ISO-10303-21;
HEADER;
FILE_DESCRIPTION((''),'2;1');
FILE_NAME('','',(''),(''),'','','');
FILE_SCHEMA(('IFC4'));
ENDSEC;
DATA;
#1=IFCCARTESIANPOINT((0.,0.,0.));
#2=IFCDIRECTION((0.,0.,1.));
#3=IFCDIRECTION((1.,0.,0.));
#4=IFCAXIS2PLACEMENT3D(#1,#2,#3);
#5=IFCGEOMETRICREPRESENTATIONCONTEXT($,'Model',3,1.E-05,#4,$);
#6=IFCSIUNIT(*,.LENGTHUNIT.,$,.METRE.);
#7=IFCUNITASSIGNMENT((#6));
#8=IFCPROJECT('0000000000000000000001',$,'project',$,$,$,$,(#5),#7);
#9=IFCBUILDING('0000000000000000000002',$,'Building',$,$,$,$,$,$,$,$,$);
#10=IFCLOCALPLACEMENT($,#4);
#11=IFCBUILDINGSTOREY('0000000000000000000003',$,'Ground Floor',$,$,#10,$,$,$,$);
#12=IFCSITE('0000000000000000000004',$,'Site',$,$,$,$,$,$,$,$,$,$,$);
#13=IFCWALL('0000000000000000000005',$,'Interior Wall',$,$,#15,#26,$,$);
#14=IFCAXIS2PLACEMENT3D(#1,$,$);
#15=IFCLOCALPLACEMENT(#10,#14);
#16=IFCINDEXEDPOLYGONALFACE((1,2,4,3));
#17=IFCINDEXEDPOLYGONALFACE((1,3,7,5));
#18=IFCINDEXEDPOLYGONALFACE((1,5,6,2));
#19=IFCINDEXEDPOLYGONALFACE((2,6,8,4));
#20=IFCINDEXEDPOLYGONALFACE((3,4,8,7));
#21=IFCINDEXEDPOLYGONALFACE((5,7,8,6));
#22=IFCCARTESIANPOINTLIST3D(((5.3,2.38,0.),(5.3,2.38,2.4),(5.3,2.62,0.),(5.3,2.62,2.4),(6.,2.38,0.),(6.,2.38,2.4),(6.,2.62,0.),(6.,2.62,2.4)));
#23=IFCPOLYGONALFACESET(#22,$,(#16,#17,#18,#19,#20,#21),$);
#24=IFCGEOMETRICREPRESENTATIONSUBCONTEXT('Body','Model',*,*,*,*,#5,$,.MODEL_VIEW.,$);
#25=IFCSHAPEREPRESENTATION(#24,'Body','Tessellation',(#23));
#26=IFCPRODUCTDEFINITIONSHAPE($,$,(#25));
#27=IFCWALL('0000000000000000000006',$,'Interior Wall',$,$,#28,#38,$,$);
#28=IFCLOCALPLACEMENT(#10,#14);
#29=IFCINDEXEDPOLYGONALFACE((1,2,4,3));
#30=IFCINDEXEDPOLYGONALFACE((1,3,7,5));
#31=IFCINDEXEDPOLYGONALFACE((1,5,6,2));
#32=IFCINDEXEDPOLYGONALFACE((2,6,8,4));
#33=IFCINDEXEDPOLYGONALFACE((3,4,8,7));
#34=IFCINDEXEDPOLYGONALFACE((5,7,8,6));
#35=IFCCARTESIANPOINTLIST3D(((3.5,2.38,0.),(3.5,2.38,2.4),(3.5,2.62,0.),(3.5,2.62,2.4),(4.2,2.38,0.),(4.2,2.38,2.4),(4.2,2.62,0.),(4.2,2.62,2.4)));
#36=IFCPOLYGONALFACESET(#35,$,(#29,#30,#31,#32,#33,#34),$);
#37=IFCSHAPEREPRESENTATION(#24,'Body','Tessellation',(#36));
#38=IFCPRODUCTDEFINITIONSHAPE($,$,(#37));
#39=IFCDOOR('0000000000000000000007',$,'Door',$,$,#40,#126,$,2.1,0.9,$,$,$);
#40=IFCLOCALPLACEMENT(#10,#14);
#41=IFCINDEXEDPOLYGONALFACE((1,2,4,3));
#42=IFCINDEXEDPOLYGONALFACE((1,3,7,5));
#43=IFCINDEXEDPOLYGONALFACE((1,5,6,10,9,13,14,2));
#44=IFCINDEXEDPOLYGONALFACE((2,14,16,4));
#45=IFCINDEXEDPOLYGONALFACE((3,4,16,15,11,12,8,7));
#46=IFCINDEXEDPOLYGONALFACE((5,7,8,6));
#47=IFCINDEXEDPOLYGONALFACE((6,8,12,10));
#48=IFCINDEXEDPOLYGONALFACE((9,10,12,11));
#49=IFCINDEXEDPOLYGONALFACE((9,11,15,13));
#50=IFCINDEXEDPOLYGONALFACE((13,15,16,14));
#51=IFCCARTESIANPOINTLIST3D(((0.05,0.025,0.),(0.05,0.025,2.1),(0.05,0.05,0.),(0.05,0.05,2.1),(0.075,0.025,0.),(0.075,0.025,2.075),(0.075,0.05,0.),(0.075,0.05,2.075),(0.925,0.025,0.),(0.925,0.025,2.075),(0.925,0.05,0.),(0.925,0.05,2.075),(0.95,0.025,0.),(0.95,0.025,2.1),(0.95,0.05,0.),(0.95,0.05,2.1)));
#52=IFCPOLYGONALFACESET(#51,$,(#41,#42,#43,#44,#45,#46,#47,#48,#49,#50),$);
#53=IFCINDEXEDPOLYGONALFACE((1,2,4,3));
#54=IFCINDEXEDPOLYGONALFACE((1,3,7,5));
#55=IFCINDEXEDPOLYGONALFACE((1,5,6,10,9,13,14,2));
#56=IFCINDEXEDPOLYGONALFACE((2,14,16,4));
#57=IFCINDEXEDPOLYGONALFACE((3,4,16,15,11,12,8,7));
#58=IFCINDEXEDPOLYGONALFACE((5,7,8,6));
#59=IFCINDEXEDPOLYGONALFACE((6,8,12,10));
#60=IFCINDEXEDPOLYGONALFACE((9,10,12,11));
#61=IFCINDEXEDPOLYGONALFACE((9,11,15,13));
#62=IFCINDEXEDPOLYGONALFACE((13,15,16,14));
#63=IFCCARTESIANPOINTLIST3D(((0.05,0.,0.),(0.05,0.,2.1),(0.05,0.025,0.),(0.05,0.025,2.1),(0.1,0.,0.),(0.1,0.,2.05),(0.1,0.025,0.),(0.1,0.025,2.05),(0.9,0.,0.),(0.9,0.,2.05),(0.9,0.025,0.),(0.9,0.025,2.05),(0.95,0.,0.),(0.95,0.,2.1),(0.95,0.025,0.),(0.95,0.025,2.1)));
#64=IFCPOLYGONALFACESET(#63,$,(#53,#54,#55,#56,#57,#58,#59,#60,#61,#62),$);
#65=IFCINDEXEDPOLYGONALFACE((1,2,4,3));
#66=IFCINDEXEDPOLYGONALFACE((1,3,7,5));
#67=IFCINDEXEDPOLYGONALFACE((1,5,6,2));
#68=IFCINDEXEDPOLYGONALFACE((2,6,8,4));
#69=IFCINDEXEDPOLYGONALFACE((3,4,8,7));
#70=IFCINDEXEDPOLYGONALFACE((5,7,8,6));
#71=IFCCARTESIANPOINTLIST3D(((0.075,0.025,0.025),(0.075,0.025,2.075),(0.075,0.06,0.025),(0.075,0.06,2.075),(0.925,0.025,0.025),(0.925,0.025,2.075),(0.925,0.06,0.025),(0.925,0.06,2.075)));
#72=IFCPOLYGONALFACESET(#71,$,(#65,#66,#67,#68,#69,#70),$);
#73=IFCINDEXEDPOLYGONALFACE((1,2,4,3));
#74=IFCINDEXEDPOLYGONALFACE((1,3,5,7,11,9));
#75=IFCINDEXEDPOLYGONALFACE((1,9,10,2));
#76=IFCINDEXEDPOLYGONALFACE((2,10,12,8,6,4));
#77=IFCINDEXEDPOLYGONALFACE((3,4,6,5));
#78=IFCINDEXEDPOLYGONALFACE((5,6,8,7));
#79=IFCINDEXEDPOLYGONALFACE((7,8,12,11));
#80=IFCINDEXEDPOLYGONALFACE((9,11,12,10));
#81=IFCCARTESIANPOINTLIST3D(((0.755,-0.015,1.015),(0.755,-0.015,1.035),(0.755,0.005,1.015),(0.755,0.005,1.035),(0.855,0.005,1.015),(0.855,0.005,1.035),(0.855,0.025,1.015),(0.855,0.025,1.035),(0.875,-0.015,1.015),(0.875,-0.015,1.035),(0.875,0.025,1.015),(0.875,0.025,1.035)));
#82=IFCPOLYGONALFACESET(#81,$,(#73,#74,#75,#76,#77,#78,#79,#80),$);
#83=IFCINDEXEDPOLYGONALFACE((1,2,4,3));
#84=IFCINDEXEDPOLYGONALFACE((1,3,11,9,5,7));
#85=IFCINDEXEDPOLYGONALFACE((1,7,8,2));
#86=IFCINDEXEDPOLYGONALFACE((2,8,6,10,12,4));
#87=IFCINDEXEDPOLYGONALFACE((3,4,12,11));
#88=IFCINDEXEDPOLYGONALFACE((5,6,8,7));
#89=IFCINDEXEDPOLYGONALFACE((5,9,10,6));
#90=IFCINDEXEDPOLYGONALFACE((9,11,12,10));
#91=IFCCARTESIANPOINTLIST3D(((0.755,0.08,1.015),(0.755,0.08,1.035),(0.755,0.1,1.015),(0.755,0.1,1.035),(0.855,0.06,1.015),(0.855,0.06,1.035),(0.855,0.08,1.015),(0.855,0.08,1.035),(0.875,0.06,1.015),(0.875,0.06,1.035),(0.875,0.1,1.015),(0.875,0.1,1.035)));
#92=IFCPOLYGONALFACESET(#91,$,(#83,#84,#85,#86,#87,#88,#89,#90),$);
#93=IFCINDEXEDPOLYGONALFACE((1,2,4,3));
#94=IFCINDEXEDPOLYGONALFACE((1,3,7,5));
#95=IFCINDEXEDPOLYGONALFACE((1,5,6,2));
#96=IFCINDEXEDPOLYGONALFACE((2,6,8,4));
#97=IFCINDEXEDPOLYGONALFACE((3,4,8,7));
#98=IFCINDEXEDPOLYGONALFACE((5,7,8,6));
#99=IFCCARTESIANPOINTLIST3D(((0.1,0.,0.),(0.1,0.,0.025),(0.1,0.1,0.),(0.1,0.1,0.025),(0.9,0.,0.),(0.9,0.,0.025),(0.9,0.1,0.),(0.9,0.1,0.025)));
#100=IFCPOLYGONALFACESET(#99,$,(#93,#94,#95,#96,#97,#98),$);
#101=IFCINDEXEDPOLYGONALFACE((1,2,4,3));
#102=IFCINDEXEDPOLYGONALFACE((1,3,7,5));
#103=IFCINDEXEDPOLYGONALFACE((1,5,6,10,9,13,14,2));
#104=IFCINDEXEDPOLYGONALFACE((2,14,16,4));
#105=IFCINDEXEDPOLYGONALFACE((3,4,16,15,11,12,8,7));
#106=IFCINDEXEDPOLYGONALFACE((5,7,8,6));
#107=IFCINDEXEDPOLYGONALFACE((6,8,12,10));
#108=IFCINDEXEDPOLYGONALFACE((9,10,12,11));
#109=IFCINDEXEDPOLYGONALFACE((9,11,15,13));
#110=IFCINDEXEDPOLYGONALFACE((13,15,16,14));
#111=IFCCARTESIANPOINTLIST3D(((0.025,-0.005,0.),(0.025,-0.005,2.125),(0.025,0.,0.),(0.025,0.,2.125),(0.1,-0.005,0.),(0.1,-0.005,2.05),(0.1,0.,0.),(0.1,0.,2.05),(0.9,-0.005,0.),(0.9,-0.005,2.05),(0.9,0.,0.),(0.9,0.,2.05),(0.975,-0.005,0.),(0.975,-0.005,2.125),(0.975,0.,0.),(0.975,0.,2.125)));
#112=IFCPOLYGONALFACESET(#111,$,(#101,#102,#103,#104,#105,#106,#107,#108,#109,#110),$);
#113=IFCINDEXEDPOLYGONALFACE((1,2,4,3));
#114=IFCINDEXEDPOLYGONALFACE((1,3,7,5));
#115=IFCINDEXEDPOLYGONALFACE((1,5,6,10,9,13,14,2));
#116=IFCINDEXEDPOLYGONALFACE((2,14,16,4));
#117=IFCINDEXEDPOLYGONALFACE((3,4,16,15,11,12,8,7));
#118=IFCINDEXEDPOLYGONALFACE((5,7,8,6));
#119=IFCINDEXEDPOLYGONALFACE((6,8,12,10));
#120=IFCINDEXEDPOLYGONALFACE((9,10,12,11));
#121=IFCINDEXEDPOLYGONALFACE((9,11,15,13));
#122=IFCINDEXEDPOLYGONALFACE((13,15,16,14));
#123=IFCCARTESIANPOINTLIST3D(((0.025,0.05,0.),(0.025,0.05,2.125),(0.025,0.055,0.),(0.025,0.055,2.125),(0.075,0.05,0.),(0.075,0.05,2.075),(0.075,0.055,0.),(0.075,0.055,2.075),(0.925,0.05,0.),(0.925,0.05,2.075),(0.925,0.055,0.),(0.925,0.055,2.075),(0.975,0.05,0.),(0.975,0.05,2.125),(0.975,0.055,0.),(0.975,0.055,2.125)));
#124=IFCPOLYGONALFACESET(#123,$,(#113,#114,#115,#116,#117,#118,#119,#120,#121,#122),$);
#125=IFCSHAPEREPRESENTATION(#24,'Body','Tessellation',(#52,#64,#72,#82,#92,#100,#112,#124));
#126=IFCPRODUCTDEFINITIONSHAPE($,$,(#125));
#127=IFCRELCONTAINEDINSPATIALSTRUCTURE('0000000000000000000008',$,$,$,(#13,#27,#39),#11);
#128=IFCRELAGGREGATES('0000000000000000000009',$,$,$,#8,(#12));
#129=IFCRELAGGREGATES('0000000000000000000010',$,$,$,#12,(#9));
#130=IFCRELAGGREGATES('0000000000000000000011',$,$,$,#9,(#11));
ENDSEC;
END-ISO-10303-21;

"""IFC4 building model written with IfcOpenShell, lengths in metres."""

from ifc_helpers import new_model, si_unit, frame, origin_with_axes, place, context, subcontext, project, spatial, line, indexed_curve, outline, extrude, element, save


model = new_model("IFC4")

# Units and contexts
model_context = context("Model", 3, precision=1e-05, world=origin_with_axes())
body_context = subcontext(model_context, "Body", "Model", "MODEL_VIEW")
ifc_project = project(units=[si_unit("LENGTHUNIT", "METRE")], contexts=[model_context])

# Site, building, storey
site = spatial("IfcSite", under=ifc_project, Name="Site")
building = spatial("IfcBuilding", under=site, Name="Building")
storey_placement = place(None, origin_with_axes())
storey = spatial("IfcBuildingStorey", under=building, at=storey_placement, Name="Ground Floor")

# Walls
for number, where, z_axis, x_axis, name in (
    (1, (6.0, 2.5, 0.0), (0.0, 0.0, 1.0), (-1.0, 0.0, 0.0), "Interior Wall"),
    (2, (4.2, 2.5, 0.0), (0.0, 0.0, 1.0), (-1.0, 0.0, 0.0), "Interior Wall"),
):
    element("IfcWall", number, at=place(storey_placement, frame(where, z_axis=z_axis, x_axis=x_axis)), inside=storey, Name=name, context=body_context, shape_type="SweptSolid", body=[
        extrude(outline(indexed_curve([(0.0, 0.0), (0.0, 0.24), (0.7, 0.24), (0.7, 0.0), (0.0, 0.0)], self_intersect=False)), frame((0.0, -0.12, 0.0), z_axis=(0.0, 0.0, 1.0), x_axis=(1.0, 0.0, 0.0)), (0.0, 0.0, 1.0), 2.4),
    ])

# Door
door_1_placement = place(storey_placement, frame((0.05, 0.0, 0.0), z_axis=(0.0, 0.0, 1.0), x_axis=(1.0, 0.0, 0.0)))
element("IfcDoor", 3, at=door_1_placement, inside=storey, Name="Door", OverallHeight=2.1, OverallWidth=0.9, context=body_context, shape_type="SweptSolid", body=[
    extrude(outline(indexed_curve([(0.0, 0.0), (0.0, 2.1), (0.9, 2.1), (0.9, 0.0), (0.875, 0.0), (0.875, 2.075), (0.025, 2.075), (0.025, 0.0)], segments=[line(1, 2, 3, 4, 5, 6, 7, 8, 1)])), frame((0.0, 0.025, 0.0), z_axis=(0.0, -1.0, 0.0), x_axis=(1.0, 0.0, 0.0)), (0.0, 0.0, -1.0), 0.025),
    extrude(outline(indexed_curve([(0.0, 0.0), (0.0, 2.1), (0.9, 2.1), (0.9, 0.0), (0.85, 0.0), (0.85, 2.05), (0.05, 2.05), (0.05, 0.0)], segments=[line(1, 2, 3, 4, 5, 6, 7, 8, 1)])), frame((0.0, 0.0, 0.0), z_axis=(0.0, -1.0, 0.0), x_axis=(1.0, 0.0, 0.0)), (0.0, 0.0, -1.0), 0.025),
    extrude(outline(indexed_curve([(0.0, 0.0), (0.85, 0.0), (0.85, 0.035), (0.0, 0.035)], segments=[line(1, 2, 3, 4, 1)])), frame((0.025, 0.025, 0.025), z_axis=(0.0, 0.0, 1.0), x_axis=(1.0, 0.0, 0.0)), (0.0, 0.0, 1.0), 2.05),
    extrude(outline(indexed_curve([(0.0, 0.0), (0.0, -0.04), (-0.12, -0.04), (-0.12, -0.02), (-0.02, -0.02), (-0.02, 0.0)], segments=[line(1, 2, 3, 4, 5, 6, 1)])), frame((0.825, 0.025, 1.015), z_axis=(0.0, 0.0, 1.0), x_axis=(1.0, 0.0, 0.0)), (0.0, 0.0, 1.0), 0.02),
    extrude(outline(indexed_curve([(0.0, 0.0), (0.0, 0.04), (-0.12, 0.04), (-0.12, 0.02), (-0.02, 0.02), (-0.02, 0.0)], segments=[line(1, 2, 3, 4, 5, 6, 1)])), frame((0.825, 0.06, 1.015), z_axis=(0.0, 0.0, 1.0), x_axis=(1.0, 0.0, 0.0)), (0.0, 0.0, 1.0), 0.02),
    extrude(outline(indexed_curve([(0.0, 0.0), (0.8, 0.0), (0.8, 0.1), (0.0, 0.1)], segments=[line(1, 2, 3, 4, 1)])), frame((0.05, 0.0, 0.0), z_axis=(0.0, 0.0, 1.0), x_axis=(1.0, 0.0, 0.0)), (0.0, 0.0, 1.0), 0.025),
    extrude(outline(indexed_curve([(0.0, 0.0), (0.0, 2.125), (0.95, 2.125), (0.95, 0.0), (0.875, 0.0), (0.875, 2.05), (0.075, 2.05), (0.075, 0.0)], segments=[line(1, 2, 3, 4, 5, 6, 7, 8, 1)])), frame((-0.025, -0.005, 0.0), z_axis=(0.0, -1.0, 0.0), x_axis=(1.0, 0.0, 0.0)), (0.0, 0.0, -1.0), 0.005),
    extrude(outline(indexed_curve([(0.0, 0.0), (0.0, 2.125), (0.95, 2.125), (0.95, 0.0), (0.9, 0.0), (0.9, 2.075), (0.05, 2.075), (0.05, 0.0)], segments=[line(1, 2, 3, 4, 5, 6, 7, 8, 1)])), frame((-0.025, 0.05, 0.0), z_axis=(0.0, -1.0, 0.0), x_axis=(1.0, 0.0, 0.0)), (0.0, 0.0, -1.0), 0.005),
])

save(model, "model.ifc")
